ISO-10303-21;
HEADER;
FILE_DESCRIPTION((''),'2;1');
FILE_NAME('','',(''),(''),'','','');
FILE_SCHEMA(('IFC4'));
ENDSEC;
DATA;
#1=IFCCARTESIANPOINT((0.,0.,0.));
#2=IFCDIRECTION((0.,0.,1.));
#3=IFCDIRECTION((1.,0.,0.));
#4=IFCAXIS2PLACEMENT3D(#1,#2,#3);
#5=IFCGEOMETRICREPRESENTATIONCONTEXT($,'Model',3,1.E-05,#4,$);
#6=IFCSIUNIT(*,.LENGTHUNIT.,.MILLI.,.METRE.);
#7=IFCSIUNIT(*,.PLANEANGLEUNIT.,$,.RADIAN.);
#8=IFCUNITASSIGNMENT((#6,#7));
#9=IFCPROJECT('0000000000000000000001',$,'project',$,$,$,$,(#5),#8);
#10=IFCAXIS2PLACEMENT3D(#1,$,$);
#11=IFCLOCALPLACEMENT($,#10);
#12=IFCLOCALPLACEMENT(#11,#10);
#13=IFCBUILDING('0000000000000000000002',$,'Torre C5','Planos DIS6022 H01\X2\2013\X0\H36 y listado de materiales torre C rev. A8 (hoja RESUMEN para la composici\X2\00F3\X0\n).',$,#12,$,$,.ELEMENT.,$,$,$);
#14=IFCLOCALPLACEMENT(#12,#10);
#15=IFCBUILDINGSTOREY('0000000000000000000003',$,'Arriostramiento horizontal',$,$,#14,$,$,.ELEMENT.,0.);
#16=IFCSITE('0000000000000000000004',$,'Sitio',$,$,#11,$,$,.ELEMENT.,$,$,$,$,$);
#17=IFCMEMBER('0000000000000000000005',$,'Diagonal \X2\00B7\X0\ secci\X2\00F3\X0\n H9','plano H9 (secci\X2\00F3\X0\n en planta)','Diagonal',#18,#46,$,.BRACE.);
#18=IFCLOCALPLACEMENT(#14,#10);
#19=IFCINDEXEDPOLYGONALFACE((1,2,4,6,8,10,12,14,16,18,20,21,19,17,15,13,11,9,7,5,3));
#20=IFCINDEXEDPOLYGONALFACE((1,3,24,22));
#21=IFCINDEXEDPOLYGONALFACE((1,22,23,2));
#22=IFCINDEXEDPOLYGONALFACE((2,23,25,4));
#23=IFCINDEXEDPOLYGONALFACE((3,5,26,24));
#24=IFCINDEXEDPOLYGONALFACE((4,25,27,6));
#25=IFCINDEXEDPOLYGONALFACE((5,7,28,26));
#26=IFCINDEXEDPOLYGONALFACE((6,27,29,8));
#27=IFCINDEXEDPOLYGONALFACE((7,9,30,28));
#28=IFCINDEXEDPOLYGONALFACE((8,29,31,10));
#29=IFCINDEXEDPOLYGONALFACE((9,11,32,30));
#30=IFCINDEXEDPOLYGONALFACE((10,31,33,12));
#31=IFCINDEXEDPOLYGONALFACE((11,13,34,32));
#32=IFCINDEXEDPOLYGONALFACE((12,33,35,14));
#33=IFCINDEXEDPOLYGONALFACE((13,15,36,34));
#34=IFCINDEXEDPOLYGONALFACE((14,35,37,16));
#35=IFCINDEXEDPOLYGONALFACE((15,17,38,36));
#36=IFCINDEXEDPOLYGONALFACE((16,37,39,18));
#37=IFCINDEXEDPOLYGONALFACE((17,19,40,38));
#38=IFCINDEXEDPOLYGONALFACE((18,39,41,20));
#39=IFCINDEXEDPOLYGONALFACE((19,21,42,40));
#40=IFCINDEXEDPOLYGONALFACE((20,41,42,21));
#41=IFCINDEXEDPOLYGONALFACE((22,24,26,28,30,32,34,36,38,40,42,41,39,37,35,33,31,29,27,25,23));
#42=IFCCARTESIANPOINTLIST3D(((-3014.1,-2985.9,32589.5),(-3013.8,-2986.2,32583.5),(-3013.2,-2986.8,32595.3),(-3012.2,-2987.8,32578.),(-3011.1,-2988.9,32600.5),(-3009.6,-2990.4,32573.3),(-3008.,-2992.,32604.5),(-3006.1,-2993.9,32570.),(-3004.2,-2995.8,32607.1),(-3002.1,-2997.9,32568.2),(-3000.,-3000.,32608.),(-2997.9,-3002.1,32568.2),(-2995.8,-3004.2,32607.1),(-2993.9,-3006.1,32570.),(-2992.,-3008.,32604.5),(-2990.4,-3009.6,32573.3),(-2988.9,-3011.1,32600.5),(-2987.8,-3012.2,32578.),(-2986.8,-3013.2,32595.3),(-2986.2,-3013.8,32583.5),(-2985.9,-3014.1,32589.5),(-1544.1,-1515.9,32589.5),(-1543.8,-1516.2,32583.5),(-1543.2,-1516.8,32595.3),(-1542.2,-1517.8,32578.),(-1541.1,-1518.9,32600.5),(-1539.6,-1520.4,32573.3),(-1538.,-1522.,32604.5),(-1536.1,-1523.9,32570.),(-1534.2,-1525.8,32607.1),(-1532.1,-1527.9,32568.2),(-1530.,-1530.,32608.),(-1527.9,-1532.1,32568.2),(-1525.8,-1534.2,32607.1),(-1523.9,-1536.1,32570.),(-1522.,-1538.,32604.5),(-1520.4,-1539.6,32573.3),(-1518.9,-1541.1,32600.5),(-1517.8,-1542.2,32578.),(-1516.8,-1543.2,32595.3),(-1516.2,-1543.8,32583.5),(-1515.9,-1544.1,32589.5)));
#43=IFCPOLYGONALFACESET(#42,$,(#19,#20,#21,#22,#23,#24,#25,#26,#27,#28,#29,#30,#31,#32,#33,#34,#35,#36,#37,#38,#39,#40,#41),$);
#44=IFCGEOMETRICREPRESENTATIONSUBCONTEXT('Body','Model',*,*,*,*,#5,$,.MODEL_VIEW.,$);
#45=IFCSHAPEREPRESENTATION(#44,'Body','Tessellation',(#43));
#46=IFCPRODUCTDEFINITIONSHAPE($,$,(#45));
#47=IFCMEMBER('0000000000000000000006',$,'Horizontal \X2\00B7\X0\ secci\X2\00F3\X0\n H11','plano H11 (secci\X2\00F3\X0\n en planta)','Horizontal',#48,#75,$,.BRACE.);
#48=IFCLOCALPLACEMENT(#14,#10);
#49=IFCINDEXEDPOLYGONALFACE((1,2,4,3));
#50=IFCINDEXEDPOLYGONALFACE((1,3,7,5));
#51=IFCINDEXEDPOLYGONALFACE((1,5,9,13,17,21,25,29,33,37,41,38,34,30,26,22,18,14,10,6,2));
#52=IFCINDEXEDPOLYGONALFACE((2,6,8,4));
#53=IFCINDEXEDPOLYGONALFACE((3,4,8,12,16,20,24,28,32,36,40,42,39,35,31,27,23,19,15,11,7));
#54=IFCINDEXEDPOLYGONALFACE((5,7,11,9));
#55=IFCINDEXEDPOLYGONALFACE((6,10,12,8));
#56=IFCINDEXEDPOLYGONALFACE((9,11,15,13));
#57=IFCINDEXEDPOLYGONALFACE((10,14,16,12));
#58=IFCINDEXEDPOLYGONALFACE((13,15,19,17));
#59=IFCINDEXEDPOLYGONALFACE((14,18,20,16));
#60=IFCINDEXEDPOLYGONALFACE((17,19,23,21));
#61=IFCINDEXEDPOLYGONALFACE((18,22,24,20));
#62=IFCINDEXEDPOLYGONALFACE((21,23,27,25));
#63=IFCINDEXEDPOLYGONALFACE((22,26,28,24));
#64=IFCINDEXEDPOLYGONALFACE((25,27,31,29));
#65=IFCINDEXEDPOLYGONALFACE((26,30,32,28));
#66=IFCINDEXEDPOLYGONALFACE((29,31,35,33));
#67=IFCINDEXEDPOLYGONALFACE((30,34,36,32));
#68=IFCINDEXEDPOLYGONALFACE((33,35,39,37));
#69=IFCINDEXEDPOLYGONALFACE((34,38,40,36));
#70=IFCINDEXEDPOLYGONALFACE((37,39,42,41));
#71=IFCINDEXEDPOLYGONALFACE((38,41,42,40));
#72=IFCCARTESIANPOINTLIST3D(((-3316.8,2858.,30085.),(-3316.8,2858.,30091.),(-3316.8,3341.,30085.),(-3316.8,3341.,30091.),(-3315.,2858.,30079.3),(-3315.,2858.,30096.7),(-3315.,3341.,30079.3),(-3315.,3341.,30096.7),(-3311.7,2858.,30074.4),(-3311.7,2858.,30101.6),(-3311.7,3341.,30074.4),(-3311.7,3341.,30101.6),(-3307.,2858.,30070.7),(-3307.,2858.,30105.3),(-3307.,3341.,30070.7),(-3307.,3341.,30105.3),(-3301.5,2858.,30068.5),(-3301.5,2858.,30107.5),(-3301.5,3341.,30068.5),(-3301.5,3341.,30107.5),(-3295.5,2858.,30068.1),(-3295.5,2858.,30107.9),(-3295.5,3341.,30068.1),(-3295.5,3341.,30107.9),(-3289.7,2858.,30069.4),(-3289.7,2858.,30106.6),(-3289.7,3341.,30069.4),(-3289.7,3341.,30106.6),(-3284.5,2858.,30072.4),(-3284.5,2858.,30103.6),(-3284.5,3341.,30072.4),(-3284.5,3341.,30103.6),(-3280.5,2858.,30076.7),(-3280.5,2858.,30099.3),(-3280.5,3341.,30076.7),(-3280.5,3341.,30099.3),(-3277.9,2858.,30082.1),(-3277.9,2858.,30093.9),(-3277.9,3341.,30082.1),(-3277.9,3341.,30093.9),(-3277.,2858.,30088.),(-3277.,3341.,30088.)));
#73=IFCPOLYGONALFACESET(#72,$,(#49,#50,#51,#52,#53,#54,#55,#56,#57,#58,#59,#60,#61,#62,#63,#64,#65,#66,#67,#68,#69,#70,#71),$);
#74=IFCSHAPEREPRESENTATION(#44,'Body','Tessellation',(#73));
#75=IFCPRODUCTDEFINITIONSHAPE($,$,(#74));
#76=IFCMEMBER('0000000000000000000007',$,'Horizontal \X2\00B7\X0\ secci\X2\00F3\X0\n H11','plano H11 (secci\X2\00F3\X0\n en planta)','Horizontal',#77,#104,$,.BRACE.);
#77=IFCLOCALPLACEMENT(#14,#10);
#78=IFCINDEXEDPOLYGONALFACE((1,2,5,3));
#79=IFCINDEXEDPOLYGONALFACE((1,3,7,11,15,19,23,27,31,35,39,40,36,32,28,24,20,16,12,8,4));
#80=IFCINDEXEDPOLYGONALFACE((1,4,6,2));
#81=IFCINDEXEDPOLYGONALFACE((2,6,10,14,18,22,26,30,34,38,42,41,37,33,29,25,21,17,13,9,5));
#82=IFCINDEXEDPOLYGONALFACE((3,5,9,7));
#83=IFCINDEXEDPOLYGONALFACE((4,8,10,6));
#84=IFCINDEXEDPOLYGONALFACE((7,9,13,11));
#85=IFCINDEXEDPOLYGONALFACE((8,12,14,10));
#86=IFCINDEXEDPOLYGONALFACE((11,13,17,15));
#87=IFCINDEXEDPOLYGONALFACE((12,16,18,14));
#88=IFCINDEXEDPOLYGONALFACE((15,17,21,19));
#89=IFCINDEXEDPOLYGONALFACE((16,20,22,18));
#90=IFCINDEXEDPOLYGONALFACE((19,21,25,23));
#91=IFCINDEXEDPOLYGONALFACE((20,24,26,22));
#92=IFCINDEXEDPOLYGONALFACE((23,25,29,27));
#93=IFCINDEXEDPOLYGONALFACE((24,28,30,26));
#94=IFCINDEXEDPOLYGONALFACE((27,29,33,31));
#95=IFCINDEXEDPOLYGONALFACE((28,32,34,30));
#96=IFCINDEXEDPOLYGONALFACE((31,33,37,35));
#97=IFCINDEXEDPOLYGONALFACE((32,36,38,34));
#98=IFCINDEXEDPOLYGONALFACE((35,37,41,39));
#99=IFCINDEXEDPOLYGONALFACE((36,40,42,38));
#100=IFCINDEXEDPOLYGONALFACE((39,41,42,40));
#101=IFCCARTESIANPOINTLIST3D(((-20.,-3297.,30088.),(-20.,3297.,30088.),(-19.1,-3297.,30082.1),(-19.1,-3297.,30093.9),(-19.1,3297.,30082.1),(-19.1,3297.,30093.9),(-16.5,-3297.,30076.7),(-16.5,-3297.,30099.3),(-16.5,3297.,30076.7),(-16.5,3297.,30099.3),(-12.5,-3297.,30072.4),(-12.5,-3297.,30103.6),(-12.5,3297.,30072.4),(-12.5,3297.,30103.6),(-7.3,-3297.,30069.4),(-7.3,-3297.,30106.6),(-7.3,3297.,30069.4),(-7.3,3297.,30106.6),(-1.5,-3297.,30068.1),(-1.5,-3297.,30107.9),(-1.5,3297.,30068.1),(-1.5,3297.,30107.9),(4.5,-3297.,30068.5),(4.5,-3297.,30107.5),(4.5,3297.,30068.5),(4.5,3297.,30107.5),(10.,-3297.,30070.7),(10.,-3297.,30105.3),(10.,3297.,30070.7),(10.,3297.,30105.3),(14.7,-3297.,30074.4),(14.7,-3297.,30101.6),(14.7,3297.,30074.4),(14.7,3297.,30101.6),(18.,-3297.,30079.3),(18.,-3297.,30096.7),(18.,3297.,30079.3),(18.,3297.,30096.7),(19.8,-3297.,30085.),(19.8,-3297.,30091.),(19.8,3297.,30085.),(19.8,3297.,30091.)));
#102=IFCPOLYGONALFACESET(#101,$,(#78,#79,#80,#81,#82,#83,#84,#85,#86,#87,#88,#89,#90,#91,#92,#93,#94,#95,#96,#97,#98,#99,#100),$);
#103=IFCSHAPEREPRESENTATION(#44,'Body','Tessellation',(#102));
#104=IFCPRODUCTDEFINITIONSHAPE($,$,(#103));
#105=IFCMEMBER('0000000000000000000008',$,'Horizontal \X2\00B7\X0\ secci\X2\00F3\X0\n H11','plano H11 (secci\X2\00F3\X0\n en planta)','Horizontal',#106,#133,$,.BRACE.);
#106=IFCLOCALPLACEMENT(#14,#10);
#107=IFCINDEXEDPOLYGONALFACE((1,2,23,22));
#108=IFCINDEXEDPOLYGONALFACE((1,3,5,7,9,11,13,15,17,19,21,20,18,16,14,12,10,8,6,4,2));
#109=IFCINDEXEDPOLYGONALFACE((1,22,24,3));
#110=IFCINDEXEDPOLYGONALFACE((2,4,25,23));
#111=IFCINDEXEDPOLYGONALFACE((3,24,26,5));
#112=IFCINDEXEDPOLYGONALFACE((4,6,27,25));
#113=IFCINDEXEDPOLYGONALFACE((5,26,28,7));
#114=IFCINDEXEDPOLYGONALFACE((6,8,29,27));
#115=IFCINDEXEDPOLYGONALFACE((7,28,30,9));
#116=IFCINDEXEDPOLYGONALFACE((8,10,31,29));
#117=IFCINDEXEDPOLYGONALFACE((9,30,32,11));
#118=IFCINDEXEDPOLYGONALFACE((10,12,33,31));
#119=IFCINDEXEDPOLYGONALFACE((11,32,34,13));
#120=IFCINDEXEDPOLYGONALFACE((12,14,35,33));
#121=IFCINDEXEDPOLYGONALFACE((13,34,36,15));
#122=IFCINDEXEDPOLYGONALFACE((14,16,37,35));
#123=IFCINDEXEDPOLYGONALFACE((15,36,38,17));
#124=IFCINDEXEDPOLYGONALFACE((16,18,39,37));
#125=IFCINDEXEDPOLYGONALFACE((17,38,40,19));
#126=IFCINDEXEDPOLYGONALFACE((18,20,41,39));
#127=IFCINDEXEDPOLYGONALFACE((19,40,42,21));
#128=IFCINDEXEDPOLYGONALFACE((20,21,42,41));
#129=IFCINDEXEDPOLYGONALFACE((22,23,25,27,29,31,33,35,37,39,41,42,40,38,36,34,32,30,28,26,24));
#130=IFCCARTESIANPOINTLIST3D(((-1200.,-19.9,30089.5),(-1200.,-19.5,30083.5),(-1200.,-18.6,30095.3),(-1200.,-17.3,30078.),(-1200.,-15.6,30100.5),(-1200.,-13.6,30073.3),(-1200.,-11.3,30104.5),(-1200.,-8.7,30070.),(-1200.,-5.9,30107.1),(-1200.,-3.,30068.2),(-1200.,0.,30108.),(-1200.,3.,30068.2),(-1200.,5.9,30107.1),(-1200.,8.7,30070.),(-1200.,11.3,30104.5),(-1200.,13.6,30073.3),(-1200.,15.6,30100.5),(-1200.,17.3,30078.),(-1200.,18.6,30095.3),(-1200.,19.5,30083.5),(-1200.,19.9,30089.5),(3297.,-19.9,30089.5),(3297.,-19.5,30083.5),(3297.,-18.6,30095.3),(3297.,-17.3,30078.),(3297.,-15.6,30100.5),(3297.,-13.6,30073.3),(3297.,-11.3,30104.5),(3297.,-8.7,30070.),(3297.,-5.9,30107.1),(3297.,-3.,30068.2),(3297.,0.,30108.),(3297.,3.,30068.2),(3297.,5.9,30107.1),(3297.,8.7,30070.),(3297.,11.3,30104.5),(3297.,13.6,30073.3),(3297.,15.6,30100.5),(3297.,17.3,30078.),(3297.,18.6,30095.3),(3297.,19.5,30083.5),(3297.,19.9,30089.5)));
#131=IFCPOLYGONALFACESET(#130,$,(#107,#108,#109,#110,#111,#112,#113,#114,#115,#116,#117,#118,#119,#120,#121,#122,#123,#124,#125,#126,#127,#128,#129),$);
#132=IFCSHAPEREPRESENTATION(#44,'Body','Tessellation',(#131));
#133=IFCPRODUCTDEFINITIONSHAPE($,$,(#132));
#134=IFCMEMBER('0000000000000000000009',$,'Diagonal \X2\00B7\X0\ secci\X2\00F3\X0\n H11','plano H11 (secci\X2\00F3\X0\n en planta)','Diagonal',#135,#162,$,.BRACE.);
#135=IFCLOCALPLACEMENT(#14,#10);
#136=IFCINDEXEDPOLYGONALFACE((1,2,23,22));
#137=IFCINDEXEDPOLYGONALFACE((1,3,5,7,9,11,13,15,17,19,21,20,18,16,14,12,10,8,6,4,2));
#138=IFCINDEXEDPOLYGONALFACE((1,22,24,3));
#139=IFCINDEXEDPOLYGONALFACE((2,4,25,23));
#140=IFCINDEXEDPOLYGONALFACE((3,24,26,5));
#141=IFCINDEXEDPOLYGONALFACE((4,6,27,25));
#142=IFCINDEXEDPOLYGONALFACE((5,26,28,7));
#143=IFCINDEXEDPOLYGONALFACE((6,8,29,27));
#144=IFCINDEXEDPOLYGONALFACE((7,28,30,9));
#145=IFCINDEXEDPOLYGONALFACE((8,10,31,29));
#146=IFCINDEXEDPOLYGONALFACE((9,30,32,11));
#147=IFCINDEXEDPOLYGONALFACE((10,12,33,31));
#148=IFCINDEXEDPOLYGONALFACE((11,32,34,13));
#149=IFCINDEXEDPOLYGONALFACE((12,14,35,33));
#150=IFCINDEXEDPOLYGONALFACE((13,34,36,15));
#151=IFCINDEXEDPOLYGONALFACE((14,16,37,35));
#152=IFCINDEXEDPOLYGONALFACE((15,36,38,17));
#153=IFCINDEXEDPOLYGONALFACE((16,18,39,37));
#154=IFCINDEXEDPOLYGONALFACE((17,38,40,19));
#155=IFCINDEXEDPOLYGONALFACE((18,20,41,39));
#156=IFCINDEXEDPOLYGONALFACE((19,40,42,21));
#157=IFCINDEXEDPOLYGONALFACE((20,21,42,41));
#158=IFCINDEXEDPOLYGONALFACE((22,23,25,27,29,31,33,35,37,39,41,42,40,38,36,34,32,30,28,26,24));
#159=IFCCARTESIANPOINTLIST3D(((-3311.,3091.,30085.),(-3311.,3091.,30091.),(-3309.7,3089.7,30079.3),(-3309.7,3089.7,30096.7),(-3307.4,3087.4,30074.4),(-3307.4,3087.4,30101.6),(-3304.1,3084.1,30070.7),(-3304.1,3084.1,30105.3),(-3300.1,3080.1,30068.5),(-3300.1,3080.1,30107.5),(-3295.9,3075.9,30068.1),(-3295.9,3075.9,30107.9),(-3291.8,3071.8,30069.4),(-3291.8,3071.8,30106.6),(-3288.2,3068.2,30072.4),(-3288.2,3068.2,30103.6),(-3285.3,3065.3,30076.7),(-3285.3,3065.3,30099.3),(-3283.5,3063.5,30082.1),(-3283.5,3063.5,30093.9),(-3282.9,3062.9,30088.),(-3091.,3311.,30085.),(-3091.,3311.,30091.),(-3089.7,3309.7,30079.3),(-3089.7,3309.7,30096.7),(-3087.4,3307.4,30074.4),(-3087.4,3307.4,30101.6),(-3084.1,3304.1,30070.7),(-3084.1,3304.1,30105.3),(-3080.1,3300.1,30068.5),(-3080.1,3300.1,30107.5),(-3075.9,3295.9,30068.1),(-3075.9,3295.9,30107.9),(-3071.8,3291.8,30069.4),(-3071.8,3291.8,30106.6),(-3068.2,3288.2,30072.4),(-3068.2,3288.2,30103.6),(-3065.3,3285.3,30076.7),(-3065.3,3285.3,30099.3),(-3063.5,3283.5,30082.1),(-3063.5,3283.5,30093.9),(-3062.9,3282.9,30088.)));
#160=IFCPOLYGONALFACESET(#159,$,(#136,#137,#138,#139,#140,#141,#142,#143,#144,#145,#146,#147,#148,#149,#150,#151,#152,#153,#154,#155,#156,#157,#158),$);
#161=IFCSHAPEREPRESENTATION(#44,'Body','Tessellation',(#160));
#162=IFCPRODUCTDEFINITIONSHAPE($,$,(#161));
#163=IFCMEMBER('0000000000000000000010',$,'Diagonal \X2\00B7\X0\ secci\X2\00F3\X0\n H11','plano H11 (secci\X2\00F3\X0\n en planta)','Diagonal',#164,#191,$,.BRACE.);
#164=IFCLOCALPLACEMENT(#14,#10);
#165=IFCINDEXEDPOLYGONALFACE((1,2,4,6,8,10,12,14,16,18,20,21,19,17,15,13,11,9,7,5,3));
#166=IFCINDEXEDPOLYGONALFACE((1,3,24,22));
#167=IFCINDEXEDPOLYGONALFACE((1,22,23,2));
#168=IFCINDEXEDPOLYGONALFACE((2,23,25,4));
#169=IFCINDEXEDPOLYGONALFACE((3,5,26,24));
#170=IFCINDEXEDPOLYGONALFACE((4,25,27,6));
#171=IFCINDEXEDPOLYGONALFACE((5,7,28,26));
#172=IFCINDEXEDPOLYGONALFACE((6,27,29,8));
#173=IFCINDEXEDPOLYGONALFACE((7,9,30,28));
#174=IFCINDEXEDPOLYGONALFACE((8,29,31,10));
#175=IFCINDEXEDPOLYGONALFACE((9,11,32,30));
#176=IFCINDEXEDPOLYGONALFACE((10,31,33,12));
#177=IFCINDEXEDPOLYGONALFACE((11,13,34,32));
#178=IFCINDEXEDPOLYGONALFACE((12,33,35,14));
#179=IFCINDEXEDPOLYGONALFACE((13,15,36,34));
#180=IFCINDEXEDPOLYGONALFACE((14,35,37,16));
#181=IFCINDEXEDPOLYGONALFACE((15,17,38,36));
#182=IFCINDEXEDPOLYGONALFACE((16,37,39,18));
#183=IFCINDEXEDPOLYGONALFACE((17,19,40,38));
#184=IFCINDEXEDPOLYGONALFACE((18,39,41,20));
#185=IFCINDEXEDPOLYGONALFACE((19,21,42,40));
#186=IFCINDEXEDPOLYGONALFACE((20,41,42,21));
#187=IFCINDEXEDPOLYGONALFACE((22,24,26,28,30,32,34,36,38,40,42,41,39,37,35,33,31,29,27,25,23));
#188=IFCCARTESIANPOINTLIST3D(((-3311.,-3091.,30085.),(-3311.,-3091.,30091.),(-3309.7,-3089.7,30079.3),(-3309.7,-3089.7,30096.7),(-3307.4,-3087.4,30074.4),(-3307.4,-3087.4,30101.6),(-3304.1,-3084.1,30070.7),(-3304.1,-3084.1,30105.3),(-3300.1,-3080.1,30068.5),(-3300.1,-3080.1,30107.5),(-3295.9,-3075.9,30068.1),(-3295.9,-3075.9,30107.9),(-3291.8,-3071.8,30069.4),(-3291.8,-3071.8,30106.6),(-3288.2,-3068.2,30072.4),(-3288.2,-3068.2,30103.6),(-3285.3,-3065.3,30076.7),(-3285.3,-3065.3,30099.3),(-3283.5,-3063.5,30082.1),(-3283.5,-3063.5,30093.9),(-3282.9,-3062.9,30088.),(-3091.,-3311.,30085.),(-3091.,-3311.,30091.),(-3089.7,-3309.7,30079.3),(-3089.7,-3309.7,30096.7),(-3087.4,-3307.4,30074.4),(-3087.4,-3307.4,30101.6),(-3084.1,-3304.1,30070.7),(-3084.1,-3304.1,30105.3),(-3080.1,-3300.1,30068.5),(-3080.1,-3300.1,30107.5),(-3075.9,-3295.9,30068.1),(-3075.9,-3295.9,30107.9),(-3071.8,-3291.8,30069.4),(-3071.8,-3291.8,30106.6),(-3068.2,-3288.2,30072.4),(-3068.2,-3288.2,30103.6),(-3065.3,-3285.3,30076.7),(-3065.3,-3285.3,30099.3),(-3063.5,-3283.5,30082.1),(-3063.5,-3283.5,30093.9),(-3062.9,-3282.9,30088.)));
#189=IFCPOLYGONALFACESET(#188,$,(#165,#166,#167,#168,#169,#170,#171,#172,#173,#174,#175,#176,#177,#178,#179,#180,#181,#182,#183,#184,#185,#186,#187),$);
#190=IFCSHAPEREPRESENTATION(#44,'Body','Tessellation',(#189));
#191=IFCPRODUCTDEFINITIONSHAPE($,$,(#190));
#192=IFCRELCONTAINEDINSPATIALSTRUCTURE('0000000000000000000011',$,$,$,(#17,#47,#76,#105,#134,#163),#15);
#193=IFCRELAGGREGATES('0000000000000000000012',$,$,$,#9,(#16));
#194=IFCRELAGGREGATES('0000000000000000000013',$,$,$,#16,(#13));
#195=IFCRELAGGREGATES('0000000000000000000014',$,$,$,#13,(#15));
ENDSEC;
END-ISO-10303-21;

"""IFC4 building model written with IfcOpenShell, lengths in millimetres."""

from ifc_helpers import new_model, si_unit, frame, origin, origin_with_axes, place, context, subcontext, project, spatial, circle, extrude, element, save


model = new_model("IFC4")

# Units and contexts
model_context = context("Model", 3, precision=1e-05, world=origin_with_axes())
body_context = subcontext(model_context, "Body", "Model", "MODEL_VIEW")
ifc_project = project(units=[si_unit("LENGTHUNIT", "METRE", prefix="MILLI"), si_unit("PLANEANGLEUNIT", "RADIAN")], contexts=[model_context])

# Site, building, storey
site_placement = place(None, origin())
site = spatial("IfcSite", under=ifc_project, at=site_placement, Name="Sitio", CompositionType="ELEMENT")
building_placement = place(site_placement, origin())
building = spatial("IfcBuilding", under=site, at=building_placement, Name="Torre C5", Description="Planos DIS6022 H01–H36 y listado de materiales torre C rev. A8 (hoja RESUMEN para la composición).", CompositionType="ELEMENT")
storey_placement = place(building_placement, origin())
storey = spatial("IfcBuildingStorey", under=building, at=storey_placement, Name="Arriostramiento horizontal", CompositionType="ELEMENT", Elevation=0.0)

# Members
for number, where, z_axis, x_axis, name in (
    (1, (-3000.0, -3000.0, 32588.0), (0.707107, 0.707107, 0.0), (0.0, 0.0, 1.0), "Diagonal · sección H9"),
):
    element("IfcMember", number, at=place(storey_placement, frame(where, z_axis=z_axis, x_axis=x_axis)), inside=storey, Name=name, Description="plano H9 (sección en planta)", ObjectType="Diagonal", PredefinedType="BRACE", context=body_context, shape_type="SweptSolid", body=[
        extrude(circle(Radius=20.0), None, (0.0, 0.0, 1.0), 2078.9),
    ])
member_1_placement = place(storey_placement, frame((-3297.0, 3341.0, 30088.0), z_axis=(0.0, -1.0, 0.0), x_axis=(1.0, 0.0, 0.0)))
element("IfcMember", 2, at=member_1_placement, inside=storey, Name="Horizontal · sección H11", Description="plano H11 (sección en planta)", ObjectType="Horizontal", PredefinedType="BRACE", context=body_context, shape_type="SweptSolid", body=[
    extrude(circle(Radius=20.0), None, (0.0, 0.0, 1.0), 483.0),
])
member_2_placement = place(storey_placement, frame((0.0, 3297.0, 30088.0), z_axis=(0.0, -1.0, 0.0), x_axis=(-1.0, 0.0, 0.0)))
element("IfcMember", 3, at=member_2_placement, inside=storey, Name="Horizontal · sección H11", Description="plano H11 (sección en planta)", ObjectType="Horizontal", PredefinedType="BRACE", context=body_context, shape_type="SweptSolid", body=[
    extrude(circle(Radius=20.0), None, (0.0, 0.0, 1.0), 6594.0),
])
member_3_placement = place(storey_placement, frame((-1200.0, 0.0, 30088.0), z_axis=(1.0, 0.0, 0.0), x_axis=(0.0, 0.0, 1.0)))
element("IfcMember", 4, at=member_3_placement, inside=storey, Name="Horizontal · sección H11", Description="plano H11 (sección en planta)", ObjectType="Horizontal", PredefinedType="BRACE", context=body_context, shape_type="SweptSolid", body=[
    extrude(circle(Radius=20.0), None, (0.0, 0.0, 1.0), 4497.0),
])
for number, where, z_axis, x_axis, name in (
    (5, (-3077.0, 3297.0, 30088.0), (-0.707107, -0.707107, 0.0), (0.707107, -0.707107, 0.0), "Diagonal · sección H11"),
    (6, (-3297.0, -3077.0, 30088.0), (0.707107, -0.707107, 0.0), (0.707107, 0.707107, 0.0), "Diagonal · sección H11"),
):
    element("IfcMember", number, at=place(storey_placement, frame(where, z_axis=z_axis, x_axis=x_axis)), inside=storey, Name=name, Description="plano H11 (sección en planta)", ObjectType="Diagonal", PredefinedType="BRACE", context=body_context, shape_type="SweptSolid", body=[
        extrude(circle(Radius=20.0), None, (0.0, 0.0, 1.0), 311.1),
    ])

save(model, "model.ifc")
